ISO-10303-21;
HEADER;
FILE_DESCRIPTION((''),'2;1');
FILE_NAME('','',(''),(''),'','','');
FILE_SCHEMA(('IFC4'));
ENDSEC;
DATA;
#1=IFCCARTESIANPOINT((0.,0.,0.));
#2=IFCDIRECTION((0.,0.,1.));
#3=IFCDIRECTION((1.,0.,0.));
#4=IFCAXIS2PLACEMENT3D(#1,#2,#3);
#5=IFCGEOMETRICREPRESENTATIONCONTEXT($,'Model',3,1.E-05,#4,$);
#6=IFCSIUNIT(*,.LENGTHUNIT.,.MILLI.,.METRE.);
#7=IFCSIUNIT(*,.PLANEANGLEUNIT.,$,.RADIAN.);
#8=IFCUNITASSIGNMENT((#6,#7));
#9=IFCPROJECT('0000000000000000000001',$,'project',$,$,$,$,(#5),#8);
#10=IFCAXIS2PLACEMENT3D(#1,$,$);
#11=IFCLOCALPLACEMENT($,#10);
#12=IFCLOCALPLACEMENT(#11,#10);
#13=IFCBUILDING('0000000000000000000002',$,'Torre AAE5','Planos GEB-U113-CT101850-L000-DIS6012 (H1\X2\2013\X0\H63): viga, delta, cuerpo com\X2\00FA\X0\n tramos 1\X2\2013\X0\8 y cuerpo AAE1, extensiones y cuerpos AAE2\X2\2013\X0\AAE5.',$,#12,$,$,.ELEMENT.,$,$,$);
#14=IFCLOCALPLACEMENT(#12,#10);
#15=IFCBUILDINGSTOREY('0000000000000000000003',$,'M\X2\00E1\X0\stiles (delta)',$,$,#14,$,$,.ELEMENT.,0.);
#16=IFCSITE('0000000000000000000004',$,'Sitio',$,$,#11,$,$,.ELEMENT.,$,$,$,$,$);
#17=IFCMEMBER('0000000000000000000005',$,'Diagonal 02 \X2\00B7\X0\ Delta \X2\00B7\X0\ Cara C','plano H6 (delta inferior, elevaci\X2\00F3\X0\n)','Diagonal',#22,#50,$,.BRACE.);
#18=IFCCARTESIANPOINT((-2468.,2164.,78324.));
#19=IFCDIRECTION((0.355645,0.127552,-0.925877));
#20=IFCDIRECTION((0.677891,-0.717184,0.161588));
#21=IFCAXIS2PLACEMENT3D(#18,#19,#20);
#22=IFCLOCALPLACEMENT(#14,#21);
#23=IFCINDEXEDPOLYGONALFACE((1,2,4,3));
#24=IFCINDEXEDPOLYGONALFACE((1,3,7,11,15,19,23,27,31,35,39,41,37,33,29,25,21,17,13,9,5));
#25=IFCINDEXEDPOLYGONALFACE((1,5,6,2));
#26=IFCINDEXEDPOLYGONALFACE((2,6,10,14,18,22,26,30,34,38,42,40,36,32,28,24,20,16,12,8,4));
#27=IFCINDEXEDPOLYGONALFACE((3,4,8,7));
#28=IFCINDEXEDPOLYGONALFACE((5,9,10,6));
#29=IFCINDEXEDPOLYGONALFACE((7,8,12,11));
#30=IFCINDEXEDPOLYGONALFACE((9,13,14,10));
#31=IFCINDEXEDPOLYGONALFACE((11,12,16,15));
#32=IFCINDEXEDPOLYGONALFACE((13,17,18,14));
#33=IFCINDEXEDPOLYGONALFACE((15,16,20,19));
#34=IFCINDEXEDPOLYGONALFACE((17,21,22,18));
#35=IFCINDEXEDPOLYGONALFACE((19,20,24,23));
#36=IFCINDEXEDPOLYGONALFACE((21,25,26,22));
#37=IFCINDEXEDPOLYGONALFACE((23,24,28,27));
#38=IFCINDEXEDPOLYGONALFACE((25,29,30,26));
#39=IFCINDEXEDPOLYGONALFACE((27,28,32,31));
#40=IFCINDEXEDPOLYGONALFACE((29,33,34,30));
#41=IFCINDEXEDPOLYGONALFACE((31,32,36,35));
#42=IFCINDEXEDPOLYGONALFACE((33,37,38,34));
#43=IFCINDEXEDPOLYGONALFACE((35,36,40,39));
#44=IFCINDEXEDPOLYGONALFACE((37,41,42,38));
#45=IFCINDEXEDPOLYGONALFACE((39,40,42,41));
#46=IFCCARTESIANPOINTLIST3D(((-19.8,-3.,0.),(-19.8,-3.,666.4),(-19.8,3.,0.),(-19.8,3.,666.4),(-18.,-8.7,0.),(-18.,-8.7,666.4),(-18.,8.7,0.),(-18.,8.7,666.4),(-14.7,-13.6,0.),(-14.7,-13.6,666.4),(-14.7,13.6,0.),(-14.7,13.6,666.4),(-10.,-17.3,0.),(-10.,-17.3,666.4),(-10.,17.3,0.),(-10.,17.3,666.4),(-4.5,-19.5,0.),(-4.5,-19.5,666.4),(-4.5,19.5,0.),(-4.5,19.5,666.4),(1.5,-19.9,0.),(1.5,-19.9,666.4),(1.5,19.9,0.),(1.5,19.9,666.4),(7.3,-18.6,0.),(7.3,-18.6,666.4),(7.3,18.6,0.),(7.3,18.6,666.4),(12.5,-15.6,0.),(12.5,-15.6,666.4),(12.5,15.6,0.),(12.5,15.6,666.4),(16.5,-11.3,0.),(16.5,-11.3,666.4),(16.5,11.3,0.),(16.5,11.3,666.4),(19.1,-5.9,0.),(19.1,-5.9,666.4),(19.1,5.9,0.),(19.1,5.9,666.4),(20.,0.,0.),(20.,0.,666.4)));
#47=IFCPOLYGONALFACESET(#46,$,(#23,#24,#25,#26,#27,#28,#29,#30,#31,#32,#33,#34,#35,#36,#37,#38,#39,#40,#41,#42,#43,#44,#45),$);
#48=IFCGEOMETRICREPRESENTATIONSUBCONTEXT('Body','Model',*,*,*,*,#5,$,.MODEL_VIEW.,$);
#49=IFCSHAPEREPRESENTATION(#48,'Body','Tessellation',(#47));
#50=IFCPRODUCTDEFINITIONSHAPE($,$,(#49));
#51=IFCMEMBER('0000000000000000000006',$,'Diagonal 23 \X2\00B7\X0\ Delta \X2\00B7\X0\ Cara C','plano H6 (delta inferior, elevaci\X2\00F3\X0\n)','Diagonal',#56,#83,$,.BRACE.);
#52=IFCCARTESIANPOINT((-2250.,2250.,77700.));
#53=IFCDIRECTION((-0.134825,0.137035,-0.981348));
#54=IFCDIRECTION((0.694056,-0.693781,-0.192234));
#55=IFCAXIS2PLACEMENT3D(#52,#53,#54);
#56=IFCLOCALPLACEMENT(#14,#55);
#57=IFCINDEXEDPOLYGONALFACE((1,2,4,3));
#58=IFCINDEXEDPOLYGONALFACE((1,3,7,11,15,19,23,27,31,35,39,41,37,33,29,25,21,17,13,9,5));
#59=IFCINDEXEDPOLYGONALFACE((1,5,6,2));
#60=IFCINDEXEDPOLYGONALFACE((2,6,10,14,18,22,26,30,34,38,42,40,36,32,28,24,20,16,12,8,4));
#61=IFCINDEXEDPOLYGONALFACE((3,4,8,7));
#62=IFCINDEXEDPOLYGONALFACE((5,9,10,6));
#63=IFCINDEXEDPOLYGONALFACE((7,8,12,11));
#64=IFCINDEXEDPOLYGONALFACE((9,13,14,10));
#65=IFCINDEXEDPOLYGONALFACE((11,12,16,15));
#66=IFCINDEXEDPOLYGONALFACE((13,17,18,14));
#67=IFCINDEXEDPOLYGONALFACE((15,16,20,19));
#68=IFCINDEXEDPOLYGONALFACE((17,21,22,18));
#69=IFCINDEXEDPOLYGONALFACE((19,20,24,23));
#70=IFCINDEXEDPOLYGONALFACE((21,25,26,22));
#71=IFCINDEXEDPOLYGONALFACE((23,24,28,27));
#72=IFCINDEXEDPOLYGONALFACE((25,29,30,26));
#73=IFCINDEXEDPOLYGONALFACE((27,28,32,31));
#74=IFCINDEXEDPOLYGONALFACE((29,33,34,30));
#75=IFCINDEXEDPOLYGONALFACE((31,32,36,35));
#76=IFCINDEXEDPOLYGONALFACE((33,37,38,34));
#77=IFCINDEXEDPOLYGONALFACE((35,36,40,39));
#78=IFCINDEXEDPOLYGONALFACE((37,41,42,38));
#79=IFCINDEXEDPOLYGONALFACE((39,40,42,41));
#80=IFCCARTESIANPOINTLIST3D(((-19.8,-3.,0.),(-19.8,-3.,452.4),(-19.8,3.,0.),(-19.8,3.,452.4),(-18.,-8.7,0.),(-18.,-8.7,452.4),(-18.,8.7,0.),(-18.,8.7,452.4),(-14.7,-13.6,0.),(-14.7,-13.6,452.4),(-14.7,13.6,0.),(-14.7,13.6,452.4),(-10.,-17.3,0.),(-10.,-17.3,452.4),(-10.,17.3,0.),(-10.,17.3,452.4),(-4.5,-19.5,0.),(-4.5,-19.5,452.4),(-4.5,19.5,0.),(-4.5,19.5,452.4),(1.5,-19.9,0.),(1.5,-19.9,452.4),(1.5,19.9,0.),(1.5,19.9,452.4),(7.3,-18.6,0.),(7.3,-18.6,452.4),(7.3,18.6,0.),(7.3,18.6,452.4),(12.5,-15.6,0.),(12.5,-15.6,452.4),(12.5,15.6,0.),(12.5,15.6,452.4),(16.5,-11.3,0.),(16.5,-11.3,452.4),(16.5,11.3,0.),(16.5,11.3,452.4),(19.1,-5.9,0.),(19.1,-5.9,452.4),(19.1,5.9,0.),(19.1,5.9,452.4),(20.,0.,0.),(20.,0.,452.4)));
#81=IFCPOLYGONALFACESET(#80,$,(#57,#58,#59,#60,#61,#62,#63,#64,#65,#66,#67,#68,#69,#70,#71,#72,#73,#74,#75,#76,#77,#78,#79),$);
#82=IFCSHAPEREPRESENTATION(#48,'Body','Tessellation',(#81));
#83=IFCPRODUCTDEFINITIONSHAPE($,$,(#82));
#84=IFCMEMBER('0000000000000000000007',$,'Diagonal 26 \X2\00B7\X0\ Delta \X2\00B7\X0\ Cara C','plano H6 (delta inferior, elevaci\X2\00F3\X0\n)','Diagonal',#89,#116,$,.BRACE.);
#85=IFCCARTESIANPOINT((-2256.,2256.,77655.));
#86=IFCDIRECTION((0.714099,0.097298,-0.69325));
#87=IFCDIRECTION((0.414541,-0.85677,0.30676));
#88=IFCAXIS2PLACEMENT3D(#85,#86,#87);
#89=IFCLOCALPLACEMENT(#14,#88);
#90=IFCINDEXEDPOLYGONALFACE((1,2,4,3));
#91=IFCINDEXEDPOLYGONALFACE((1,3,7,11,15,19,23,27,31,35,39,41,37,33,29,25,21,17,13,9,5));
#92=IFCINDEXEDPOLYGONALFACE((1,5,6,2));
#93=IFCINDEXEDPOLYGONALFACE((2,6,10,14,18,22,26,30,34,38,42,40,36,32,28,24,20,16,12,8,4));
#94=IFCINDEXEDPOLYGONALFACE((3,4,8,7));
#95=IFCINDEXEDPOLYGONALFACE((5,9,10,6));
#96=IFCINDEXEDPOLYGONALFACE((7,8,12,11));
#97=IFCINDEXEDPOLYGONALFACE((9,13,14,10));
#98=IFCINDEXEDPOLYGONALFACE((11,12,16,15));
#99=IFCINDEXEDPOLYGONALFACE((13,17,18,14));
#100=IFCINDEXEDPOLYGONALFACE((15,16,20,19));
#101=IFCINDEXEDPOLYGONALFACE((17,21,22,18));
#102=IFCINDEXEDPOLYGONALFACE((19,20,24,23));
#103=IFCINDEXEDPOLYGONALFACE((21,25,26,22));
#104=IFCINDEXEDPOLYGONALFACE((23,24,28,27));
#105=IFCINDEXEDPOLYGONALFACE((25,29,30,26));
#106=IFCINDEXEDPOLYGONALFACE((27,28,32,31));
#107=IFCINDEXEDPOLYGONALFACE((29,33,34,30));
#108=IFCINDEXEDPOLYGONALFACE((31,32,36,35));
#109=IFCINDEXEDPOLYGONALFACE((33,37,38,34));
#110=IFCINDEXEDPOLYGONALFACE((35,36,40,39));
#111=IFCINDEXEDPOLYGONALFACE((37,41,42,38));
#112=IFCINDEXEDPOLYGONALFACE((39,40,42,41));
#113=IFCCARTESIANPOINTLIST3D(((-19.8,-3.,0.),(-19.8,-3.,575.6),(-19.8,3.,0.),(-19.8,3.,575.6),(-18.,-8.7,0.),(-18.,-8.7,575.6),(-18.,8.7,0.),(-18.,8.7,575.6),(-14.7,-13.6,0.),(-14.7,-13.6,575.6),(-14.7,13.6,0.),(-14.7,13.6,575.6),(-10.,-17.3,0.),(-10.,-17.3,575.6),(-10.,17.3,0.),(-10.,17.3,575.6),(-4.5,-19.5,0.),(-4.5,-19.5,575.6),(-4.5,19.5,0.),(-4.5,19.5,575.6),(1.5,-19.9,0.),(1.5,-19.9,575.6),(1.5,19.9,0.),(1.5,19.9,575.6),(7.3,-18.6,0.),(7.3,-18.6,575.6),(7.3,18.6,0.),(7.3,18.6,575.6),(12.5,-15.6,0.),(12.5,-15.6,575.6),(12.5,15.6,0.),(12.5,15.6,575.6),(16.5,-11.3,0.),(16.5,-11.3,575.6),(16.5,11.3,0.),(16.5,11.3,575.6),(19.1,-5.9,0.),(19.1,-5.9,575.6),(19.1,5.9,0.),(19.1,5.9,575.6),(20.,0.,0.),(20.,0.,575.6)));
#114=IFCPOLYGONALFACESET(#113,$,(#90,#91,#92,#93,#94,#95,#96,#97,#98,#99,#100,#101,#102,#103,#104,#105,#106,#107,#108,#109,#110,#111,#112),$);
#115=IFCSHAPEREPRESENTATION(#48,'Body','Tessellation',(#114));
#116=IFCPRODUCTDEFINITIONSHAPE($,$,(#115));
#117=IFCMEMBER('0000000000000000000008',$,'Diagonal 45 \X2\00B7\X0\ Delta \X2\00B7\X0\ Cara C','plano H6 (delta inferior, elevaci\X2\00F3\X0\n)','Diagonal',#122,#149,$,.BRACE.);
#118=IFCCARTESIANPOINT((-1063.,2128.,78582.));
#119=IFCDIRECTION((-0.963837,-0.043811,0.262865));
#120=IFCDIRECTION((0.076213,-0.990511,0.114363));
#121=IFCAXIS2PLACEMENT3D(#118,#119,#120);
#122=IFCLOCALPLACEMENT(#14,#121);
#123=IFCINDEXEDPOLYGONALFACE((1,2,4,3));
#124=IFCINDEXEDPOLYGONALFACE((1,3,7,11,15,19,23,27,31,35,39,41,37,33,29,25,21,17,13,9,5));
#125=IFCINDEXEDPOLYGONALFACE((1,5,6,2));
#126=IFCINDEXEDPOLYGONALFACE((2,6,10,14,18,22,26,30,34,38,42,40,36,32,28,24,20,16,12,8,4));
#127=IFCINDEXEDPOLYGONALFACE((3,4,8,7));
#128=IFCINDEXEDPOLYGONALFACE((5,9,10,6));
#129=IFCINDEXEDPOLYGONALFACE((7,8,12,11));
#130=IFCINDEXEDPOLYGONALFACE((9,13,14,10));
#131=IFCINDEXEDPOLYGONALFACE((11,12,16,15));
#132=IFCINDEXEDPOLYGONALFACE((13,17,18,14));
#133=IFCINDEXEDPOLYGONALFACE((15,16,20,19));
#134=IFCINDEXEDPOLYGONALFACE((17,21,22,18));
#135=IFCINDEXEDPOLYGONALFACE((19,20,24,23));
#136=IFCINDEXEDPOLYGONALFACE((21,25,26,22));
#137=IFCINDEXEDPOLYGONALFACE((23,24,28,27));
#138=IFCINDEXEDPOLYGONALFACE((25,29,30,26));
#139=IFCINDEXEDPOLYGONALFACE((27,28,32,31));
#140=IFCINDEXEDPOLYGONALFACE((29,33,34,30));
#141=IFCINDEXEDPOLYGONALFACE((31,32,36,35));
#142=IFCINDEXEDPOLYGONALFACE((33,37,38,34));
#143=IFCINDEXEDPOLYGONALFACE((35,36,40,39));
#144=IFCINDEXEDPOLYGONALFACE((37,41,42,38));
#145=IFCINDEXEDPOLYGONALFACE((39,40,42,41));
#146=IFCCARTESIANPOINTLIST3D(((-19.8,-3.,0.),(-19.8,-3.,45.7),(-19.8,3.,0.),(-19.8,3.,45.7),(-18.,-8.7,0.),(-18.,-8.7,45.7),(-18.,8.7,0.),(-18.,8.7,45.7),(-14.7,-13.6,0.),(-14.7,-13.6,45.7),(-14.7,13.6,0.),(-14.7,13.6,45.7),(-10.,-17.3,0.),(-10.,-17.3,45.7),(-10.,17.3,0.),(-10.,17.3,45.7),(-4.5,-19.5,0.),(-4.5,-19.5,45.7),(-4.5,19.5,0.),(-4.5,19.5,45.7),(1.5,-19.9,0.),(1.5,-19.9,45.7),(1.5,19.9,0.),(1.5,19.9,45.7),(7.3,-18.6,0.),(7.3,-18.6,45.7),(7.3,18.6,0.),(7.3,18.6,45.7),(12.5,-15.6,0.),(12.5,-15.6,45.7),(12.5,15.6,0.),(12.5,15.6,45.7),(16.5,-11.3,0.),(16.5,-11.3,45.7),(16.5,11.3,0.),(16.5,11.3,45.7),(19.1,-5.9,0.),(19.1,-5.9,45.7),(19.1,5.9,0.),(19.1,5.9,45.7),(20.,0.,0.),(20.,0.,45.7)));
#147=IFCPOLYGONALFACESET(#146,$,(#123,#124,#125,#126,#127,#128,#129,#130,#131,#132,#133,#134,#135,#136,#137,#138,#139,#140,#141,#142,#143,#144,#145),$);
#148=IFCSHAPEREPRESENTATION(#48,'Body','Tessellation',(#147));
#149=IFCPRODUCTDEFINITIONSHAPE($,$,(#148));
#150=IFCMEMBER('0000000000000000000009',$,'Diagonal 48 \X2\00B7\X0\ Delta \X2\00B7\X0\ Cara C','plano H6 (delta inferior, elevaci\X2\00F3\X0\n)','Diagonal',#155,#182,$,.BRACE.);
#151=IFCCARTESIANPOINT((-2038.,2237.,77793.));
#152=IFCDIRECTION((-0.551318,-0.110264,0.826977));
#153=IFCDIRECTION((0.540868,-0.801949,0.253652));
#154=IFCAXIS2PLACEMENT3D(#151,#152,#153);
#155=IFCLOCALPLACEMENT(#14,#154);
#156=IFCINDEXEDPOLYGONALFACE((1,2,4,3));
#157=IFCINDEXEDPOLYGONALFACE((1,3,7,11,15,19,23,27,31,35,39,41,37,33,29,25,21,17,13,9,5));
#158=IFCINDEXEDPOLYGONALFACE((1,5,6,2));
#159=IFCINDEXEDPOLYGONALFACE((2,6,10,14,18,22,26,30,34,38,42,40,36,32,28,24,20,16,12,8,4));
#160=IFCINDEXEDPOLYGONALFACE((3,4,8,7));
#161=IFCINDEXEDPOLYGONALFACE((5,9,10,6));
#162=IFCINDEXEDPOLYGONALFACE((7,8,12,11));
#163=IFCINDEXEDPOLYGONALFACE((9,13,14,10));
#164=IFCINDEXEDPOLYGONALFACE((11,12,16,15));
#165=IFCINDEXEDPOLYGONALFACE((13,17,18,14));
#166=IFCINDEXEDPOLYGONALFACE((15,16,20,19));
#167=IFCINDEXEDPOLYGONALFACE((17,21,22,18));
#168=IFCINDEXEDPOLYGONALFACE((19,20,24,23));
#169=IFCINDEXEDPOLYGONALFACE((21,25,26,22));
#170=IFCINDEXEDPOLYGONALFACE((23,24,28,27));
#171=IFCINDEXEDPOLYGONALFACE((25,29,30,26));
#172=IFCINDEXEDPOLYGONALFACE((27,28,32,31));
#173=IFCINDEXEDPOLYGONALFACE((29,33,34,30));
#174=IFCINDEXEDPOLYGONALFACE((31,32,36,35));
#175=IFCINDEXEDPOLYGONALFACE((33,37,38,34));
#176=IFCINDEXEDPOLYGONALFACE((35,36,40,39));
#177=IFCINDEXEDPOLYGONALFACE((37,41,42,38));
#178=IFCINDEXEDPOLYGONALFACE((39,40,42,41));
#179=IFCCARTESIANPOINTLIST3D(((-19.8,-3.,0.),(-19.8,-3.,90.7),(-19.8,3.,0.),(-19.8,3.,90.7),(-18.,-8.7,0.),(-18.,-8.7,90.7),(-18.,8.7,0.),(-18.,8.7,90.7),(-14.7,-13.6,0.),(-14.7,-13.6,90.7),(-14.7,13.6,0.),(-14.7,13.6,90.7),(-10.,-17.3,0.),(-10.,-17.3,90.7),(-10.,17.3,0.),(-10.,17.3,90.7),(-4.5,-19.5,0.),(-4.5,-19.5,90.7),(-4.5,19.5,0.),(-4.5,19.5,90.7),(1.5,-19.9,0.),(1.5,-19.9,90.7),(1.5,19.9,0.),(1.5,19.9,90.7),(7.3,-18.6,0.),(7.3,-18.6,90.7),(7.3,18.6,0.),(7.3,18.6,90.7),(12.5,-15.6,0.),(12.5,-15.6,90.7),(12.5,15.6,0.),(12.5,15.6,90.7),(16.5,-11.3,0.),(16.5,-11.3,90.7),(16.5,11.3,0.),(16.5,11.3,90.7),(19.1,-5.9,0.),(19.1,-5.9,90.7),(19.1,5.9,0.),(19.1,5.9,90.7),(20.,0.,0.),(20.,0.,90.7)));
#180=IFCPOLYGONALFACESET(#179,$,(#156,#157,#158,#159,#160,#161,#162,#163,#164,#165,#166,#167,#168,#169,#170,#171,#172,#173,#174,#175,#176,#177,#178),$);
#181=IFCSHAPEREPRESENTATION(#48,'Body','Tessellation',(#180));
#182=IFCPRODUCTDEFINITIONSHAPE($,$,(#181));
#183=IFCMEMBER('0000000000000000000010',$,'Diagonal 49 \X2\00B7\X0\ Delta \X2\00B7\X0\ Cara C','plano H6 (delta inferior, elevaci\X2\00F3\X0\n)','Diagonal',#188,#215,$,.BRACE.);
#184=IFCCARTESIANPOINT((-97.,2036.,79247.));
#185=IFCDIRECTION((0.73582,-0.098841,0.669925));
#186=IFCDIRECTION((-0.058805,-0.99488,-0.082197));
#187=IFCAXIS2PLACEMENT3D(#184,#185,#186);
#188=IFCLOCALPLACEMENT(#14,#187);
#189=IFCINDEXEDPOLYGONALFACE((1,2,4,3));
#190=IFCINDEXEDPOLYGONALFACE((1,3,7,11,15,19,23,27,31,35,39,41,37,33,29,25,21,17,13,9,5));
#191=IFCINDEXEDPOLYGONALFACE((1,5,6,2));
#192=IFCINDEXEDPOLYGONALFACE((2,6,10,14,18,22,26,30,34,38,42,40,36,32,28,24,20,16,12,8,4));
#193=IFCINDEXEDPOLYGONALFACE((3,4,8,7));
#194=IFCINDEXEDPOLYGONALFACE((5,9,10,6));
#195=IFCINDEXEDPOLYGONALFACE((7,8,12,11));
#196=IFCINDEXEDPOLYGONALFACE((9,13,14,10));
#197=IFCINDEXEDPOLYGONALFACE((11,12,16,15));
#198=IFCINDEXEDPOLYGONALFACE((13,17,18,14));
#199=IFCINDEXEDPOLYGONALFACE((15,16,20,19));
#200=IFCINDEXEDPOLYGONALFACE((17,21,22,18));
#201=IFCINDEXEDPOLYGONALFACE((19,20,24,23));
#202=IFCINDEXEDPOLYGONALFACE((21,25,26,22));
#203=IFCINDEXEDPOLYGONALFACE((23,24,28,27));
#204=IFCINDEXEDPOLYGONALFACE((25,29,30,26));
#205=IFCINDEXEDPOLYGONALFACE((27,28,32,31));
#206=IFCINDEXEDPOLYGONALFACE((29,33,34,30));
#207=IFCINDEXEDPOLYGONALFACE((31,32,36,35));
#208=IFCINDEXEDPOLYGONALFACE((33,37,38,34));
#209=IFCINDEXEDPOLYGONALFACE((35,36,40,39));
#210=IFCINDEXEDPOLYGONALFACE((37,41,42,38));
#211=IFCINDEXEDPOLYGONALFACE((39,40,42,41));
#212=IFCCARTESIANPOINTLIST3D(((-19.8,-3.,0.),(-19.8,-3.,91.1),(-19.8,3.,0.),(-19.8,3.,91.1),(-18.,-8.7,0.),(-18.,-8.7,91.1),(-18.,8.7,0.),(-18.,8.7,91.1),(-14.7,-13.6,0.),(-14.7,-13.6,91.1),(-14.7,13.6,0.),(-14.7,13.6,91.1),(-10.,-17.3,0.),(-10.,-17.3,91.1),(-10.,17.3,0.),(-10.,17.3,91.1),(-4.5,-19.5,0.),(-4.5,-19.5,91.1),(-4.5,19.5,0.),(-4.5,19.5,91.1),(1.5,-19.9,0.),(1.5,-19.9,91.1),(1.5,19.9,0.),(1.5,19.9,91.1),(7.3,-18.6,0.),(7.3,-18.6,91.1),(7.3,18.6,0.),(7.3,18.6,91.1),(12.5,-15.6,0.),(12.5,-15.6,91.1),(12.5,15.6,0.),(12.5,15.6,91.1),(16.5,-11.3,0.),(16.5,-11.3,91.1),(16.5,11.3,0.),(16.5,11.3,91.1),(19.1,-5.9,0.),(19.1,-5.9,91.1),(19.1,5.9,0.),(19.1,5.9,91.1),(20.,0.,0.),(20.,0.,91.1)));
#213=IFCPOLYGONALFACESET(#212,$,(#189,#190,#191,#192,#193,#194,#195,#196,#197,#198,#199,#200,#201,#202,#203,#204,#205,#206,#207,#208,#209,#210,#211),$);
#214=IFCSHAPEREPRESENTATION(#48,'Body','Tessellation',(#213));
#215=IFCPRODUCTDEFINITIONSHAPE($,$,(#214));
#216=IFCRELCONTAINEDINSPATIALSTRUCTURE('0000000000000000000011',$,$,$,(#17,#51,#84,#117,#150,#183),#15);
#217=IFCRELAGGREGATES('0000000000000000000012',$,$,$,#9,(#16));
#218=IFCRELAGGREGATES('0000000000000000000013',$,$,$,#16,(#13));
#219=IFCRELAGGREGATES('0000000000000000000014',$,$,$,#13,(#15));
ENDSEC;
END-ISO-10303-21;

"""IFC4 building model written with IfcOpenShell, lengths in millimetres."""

from ifc_helpers import new_model, si_unit, frame, origin, origin_with_axes, place, context, subcontext, project, spatial, circle, extrude, element, save


model = new_model("IFC4")

# Units and contexts
model_context = context("Model", 3, precision=1e-05, world=origin_with_axes())
body_context = subcontext(model_context, "Body", "Model", "MODEL_VIEW")
ifc_project = project(units=[si_unit("LENGTHUNIT", "METRE", prefix="MILLI"), si_unit("PLANEANGLEUNIT", "RADIAN")], contexts=[model_context])

# Site, building, storey
site_placement = place(None, origin())
site = spatial("IfcSite", under=ifc_project, at=site_placement, Name="Sitio", CompositionType="ELEMENT")
building_placement = place(site_placement, origin())
building = spatial("IfcBuilding", under=site, at=building_placement, Name="Torre AAE5", Description="Planos GEB-U113-CT101850-L000-DIS6012 (H1–H63): viga, delta, cuerpo común tramos 1–8 y cuerpo AAE1, extensiones y cuerpos AAE2–AAE5.", CompositionType="ELEMENT")
storey_placement = place(building_placement, origin())
storey = spatial("IfcBuildingStorey", under=building, at=storey_placement, Name="Mástiles (delta)", CompositionType="ELEMENT", Elevation=0.0)

# Members
member_1_placement = place(storey_placement, frame((-2468.0, 2164.0, 78324.0), z_axis=(0.355645, 0.127552, -0.925877), x_axis=(0.677891, -0.717184, 0.161588)))
element("IfcMember", 1, at=member_1_placement, inside=storey, Name="Diagonal 02 · Delta · Cara C", Description="plano H6 (delta inferior, elevación)", ObjectType="Diagonal", PredefinedType="BRACE", context=body_context, shape_type="SweptSolid", body=[
    extrude(circle(Radius=20.0), None, (0.0, 0.0, 1.0), 666.4),
])
member_2_placement = place(storey_placement, frame((-2250.0, 2250.0, 77700.0), z_axis=(-0.134825, 0.137035, -0.981348), x_axis=(0.694056, -0.693781, -0.192234)))
element("IfcMember", 2, at=member_2_placement, inside=storey, Name="Diagonal 23 · Delta · Cara C", Description="plano H6 (delta inferior, elevación)", ObjectType="Diagonal", PredefinedType="BRACE", context=body_context, shape_type="SweptSolid", body=[
    extrude(circle(Radius=20.0), None, (0.0, 0.0, 1.0), 452.4),
])
member_3_placement = place(storey_placement, frame((-2256.0, 2256.0, 77655.0), z_axis=(0.714099, 0.097298, -0.69325), x_axis=(0.414541, -0.85677, 0.30676)))
element("IfcMember", 3, at=member_3_placement, inside=storey, Name="Diagonal 26 · Delta · Cara C", Description="plano H6 (delta inferior, elevación)", ObjectType="Diagonal", PredefinedType="BRACE", context=body_context, shape_type="SweptSolid", body=[
    extrude(circle(Radius=20.0), None, (0.0, 0.0, 1.0), 575.6),
])
member_4_placement = place(storey_placement, frame((-1063.0, 2128.0, 78582.0), z_axis=(-0.963837, -0.043811, 0.262865), x_axis=(0.076213, -0.990511, 0.114363)))
element("IfcMember", 4, at=member_4_placement, inside=storey, Name="Diagonal 45 · Delta · Cara C", Description="plano H6 (delta inferior, elevación)", ObjectType="Diagonal", PredefinedType="BRACE", context=body_context, shape_type="SweptSolid", body=[
    extrude(circle(Radius=20.0), None, (0.0, 0.0, 1.0), 45.7),
])
member_5_placement = place(storey_placement, frame((-2038.0, 2237.0, 77793.0), z_axis=(-0.551318, -0.110264, 0.826977), x_axis=(0.540868, -0.801949, 0.253652)))
element("IfcMember", 5, at=member_5_placement, inside=storey, Name="Diagonal 48 · Delta · Cara C", Description="plano H6 (delta inferior, elevación)", ObjectType="Diagonal", PredefinedType="BRACE", context=body_context, shape_type="SweptSolid", body=[
    extrude(circle(Radius=20.0), None, (0.0, 0.0, 1.0), 90.7),
])
member_6_placement = place(storey_placement, frame((-97.0, 2036.0, 79247.0), z_axis=(0.73582, -0.098841, 0.669925), x_axis=(-0.058805, -0.99488, -0.082197)))
element("IfcMember", 6, at=member_6_placement, inside=storey, Name="Diagonal 49 · Delta · Cara C", Description="plano H6 (delta inferior, elevación)", ObjectType="Diagonal", PredefinedType="BRACE", context=body_context, shape_type="SweptSolid", body=[
    extrude(circle(Radius=20.0), None, (0.0, 0.0, 1.0), 91.1),
])

save(model, "model.ifc")
